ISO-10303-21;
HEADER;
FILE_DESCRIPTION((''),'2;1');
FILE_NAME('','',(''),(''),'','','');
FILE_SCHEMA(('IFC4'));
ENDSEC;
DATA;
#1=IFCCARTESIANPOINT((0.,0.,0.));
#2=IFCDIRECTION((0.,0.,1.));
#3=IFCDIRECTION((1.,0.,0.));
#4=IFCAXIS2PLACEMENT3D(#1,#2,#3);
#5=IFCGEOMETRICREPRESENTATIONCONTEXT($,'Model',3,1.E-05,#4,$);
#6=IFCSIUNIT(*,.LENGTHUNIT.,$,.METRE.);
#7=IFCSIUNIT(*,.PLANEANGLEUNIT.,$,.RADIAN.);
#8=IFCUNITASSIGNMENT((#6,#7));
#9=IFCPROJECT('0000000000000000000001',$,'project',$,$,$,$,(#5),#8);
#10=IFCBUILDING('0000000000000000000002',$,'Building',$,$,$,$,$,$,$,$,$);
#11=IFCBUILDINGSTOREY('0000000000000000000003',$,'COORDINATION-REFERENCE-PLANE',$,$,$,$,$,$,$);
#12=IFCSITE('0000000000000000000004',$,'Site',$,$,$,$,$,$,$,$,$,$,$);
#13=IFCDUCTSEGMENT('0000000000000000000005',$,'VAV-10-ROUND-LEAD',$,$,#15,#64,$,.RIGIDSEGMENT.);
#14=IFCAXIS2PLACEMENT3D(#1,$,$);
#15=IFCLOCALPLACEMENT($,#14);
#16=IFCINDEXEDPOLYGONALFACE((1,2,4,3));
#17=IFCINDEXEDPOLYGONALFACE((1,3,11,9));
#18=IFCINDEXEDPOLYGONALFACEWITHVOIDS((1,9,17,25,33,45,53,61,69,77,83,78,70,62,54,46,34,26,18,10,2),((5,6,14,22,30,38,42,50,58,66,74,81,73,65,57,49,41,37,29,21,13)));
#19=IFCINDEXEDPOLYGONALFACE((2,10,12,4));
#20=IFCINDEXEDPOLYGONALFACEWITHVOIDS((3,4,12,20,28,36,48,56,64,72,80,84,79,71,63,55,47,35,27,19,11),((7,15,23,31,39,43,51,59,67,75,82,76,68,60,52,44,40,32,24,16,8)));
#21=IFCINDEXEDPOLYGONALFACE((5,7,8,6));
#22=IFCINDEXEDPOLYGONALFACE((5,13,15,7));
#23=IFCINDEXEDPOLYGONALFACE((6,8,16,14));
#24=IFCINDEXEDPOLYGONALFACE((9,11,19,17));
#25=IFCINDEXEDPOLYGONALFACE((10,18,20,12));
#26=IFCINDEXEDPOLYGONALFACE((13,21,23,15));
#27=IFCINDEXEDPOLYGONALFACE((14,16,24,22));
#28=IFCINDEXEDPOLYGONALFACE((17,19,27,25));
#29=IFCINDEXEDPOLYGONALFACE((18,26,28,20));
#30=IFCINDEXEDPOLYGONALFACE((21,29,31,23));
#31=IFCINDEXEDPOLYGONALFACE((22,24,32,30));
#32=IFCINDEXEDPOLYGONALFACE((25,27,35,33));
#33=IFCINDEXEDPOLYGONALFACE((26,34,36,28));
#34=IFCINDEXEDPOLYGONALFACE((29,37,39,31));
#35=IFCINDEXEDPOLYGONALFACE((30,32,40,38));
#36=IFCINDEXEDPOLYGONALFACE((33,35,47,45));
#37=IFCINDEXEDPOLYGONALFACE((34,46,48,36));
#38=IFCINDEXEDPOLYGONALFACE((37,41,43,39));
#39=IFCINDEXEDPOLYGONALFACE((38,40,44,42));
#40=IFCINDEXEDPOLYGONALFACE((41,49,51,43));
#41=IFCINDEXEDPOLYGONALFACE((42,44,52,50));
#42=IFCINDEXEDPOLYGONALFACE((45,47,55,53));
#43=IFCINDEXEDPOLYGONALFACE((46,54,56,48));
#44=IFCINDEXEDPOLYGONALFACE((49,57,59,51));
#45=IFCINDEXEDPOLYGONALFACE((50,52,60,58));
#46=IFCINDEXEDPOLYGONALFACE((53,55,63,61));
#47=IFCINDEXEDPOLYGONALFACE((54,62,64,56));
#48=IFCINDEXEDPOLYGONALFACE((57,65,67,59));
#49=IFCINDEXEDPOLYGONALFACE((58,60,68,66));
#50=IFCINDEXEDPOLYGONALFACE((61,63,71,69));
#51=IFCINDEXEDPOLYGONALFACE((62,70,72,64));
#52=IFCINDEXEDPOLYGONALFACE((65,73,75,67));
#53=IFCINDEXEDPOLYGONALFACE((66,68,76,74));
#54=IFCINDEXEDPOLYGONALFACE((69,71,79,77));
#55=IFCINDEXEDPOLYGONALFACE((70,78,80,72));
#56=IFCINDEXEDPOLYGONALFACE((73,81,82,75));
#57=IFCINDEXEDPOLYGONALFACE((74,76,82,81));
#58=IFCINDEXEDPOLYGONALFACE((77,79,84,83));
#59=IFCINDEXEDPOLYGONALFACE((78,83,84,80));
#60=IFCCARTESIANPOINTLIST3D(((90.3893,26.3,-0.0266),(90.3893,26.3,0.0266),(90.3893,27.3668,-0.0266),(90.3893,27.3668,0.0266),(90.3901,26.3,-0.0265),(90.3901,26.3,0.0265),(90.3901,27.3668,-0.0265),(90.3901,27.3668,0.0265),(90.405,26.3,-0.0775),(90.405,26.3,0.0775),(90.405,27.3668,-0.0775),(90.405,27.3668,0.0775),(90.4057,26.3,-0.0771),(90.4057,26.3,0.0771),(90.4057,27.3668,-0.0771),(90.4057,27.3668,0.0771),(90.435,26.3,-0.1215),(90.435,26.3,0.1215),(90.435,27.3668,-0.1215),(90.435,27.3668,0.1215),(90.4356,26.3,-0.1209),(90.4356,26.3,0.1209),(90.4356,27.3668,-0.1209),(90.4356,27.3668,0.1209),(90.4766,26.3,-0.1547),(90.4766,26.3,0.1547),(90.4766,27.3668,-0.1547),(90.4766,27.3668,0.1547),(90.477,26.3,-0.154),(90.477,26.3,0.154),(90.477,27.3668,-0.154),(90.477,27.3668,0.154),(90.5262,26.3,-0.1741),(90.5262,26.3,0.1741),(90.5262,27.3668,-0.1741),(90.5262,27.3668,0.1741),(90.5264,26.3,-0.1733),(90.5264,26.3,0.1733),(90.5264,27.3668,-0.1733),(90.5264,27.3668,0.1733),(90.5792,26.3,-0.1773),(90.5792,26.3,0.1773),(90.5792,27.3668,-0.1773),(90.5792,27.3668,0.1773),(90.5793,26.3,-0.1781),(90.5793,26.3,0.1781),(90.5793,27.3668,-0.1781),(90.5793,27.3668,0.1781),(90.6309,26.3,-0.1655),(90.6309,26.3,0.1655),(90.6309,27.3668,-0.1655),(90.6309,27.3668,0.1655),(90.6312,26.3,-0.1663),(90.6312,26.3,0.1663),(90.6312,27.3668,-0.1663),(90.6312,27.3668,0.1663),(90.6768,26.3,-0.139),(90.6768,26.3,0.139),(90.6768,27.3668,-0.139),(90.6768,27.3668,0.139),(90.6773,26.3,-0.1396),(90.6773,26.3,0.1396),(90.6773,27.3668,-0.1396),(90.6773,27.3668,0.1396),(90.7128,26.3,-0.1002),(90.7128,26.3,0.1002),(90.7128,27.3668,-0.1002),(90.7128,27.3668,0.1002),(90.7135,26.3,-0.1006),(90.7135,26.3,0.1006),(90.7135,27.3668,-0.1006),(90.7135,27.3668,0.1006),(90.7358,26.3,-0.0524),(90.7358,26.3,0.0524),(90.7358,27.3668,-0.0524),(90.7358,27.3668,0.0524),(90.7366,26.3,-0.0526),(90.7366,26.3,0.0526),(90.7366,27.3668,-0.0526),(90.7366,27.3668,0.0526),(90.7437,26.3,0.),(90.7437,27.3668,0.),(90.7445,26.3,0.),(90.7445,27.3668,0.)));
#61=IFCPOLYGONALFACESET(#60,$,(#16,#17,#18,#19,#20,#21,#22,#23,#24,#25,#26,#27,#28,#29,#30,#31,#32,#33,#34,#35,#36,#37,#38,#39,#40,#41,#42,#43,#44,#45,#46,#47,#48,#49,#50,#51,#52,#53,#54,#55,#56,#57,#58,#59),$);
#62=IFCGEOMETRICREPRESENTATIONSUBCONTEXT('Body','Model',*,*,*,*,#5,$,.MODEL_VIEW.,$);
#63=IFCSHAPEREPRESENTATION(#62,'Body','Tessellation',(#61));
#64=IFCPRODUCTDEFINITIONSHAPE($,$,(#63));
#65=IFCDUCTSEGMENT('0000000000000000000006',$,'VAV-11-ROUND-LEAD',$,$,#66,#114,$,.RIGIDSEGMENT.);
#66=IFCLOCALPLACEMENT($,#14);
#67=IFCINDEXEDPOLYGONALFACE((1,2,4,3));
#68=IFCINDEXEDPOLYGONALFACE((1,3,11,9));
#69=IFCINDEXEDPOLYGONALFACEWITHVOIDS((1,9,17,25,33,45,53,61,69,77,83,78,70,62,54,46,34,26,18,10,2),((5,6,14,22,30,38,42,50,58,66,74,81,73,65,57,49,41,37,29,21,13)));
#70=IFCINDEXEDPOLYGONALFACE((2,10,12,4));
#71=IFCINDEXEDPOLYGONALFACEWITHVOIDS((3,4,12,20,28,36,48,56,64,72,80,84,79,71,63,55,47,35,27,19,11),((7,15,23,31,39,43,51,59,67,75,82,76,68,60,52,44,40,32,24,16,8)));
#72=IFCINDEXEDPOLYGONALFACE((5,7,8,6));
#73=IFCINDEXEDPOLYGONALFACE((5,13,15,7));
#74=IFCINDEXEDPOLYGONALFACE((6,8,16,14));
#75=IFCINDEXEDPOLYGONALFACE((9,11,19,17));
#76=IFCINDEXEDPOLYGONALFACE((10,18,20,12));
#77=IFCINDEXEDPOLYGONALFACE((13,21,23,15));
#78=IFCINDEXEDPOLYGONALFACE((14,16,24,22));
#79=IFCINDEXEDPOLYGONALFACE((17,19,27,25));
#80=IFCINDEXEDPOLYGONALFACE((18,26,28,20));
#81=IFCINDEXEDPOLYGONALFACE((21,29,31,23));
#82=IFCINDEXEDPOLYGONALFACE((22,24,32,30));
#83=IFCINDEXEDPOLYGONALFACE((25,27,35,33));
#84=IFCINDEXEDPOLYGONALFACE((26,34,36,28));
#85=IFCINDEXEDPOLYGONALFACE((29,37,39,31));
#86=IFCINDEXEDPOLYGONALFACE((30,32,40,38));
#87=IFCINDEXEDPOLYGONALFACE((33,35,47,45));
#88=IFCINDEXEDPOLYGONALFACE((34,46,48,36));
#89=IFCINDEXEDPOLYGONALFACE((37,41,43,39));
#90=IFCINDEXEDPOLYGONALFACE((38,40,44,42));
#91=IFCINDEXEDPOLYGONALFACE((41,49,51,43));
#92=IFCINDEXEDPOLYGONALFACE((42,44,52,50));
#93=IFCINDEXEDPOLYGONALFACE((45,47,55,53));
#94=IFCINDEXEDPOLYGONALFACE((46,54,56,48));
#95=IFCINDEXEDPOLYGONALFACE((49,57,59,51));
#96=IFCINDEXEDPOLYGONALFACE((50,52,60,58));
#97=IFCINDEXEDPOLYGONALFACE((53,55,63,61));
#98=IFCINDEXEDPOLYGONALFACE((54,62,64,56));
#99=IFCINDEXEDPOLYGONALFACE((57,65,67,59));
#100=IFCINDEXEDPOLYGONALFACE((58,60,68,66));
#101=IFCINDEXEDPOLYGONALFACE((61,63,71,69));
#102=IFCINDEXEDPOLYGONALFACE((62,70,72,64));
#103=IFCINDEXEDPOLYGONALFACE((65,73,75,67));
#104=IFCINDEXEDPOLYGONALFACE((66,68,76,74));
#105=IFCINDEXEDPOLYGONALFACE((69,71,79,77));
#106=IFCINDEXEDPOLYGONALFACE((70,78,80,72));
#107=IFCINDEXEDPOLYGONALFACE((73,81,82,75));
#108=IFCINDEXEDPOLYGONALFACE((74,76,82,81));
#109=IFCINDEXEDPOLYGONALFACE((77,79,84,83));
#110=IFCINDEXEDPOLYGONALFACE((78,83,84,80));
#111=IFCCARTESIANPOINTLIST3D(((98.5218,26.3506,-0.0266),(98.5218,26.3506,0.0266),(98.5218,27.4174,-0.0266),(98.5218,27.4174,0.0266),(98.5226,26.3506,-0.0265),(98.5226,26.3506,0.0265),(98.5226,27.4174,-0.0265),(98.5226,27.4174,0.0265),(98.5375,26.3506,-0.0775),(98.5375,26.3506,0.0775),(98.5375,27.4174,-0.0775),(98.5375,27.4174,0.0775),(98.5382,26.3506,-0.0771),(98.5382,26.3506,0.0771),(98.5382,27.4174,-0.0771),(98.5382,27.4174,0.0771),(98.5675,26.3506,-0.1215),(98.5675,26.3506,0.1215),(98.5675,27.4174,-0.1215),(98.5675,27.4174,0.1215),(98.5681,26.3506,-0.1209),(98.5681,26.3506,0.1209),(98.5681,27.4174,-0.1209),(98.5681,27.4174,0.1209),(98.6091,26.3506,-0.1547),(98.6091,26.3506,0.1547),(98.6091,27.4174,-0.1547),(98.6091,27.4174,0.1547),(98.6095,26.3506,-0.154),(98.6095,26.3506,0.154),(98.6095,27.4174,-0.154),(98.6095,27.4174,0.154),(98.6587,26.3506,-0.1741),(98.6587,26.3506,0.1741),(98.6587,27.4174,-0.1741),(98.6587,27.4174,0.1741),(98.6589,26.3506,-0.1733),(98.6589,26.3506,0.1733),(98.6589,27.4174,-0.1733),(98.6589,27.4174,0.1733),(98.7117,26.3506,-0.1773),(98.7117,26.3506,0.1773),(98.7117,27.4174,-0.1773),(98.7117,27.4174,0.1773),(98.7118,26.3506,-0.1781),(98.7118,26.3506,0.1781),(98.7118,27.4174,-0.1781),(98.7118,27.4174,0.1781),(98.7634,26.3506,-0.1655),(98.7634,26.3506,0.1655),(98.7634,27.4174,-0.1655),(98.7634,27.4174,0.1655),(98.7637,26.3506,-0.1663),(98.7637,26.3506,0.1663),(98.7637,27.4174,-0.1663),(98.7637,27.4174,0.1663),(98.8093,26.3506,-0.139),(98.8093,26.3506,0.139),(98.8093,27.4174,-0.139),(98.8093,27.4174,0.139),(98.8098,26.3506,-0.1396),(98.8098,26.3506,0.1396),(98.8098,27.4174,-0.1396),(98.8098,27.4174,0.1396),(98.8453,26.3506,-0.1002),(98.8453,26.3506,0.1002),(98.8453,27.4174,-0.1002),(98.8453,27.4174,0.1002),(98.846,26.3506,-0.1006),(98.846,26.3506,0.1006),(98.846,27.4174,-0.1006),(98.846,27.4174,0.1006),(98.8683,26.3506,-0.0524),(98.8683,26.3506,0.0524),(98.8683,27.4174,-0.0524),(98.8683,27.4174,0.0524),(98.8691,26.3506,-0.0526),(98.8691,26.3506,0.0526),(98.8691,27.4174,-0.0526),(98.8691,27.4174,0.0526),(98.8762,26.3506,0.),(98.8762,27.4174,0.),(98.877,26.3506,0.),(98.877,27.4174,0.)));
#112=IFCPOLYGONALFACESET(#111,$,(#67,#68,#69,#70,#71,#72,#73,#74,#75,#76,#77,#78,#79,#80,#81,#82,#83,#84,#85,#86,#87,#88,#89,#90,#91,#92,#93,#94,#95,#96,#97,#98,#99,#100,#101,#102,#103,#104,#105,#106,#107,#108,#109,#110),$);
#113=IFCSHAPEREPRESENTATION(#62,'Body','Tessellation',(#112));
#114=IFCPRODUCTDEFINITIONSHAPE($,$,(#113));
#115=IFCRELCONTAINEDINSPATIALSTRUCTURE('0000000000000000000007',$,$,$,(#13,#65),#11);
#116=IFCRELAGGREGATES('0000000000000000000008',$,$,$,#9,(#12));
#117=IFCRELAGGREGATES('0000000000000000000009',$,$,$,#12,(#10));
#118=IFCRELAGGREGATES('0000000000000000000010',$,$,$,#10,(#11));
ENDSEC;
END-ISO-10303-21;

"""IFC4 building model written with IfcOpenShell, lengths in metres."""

from ifc_helpers import new_model, si_unit, frame, origin, origin_with_axes, place, context, subcontext, project, spatial, hollow_circle, extrude, element, save


model = new_model("IFC4")

# Units and contexts
model_context_1 = context("Model", 3, precision=1e-05, world=origin_with_axes())
body_context_1 = subcontext(model_context_1, "Body", "Model", "MODEL_VIEW")
ifc_project = project(units=[si_unit("LENGTHUNIT", "METRE"), si_unit("PLANEANGLEUNIT", "RADIAN")], contexts=[model_context_1])

# Site, building, storey
site = spatial("IfcSite", under=ifc_project, Name="Site")
building = spatial("IfcBuilding", under=site, Name="Building")
storey = spatial("IfcBuildingStorey", under=building, Name="COORDINATION-REFERENCE-PLANE")

# Duct segments
for number, where, z_axis, x_axis, name in (
    (1, (90.5659, 27.3668, 0.0), (0.0, -1.0, 0.0), (1.0, 0.0, 0.0), "VAV-10-ROUND-LEAD"),
    (2, (98.6984, 27.4174, 0.0), (0.0, -1.0, 0.0), (1.0, 0.0, 0.0), "VAV-11-ROUND-LEAD"),
):
    element("IfcDuctSegment", number, at=place(None, frame(where, z_axis=z_axis, x_axis=x_axis)), inside=storey, Name=name, PredefinedType="RIGIDSEGMENT", context=body_context_1, shape_type="SweptSolid", body=[
        extrude(hollow_circle(Radius=0.1786, WallThickness=0.0008), origin(), (0.0, 0.0, 1.0), 1.0668),
    ])

save(model, "model.ifc")
